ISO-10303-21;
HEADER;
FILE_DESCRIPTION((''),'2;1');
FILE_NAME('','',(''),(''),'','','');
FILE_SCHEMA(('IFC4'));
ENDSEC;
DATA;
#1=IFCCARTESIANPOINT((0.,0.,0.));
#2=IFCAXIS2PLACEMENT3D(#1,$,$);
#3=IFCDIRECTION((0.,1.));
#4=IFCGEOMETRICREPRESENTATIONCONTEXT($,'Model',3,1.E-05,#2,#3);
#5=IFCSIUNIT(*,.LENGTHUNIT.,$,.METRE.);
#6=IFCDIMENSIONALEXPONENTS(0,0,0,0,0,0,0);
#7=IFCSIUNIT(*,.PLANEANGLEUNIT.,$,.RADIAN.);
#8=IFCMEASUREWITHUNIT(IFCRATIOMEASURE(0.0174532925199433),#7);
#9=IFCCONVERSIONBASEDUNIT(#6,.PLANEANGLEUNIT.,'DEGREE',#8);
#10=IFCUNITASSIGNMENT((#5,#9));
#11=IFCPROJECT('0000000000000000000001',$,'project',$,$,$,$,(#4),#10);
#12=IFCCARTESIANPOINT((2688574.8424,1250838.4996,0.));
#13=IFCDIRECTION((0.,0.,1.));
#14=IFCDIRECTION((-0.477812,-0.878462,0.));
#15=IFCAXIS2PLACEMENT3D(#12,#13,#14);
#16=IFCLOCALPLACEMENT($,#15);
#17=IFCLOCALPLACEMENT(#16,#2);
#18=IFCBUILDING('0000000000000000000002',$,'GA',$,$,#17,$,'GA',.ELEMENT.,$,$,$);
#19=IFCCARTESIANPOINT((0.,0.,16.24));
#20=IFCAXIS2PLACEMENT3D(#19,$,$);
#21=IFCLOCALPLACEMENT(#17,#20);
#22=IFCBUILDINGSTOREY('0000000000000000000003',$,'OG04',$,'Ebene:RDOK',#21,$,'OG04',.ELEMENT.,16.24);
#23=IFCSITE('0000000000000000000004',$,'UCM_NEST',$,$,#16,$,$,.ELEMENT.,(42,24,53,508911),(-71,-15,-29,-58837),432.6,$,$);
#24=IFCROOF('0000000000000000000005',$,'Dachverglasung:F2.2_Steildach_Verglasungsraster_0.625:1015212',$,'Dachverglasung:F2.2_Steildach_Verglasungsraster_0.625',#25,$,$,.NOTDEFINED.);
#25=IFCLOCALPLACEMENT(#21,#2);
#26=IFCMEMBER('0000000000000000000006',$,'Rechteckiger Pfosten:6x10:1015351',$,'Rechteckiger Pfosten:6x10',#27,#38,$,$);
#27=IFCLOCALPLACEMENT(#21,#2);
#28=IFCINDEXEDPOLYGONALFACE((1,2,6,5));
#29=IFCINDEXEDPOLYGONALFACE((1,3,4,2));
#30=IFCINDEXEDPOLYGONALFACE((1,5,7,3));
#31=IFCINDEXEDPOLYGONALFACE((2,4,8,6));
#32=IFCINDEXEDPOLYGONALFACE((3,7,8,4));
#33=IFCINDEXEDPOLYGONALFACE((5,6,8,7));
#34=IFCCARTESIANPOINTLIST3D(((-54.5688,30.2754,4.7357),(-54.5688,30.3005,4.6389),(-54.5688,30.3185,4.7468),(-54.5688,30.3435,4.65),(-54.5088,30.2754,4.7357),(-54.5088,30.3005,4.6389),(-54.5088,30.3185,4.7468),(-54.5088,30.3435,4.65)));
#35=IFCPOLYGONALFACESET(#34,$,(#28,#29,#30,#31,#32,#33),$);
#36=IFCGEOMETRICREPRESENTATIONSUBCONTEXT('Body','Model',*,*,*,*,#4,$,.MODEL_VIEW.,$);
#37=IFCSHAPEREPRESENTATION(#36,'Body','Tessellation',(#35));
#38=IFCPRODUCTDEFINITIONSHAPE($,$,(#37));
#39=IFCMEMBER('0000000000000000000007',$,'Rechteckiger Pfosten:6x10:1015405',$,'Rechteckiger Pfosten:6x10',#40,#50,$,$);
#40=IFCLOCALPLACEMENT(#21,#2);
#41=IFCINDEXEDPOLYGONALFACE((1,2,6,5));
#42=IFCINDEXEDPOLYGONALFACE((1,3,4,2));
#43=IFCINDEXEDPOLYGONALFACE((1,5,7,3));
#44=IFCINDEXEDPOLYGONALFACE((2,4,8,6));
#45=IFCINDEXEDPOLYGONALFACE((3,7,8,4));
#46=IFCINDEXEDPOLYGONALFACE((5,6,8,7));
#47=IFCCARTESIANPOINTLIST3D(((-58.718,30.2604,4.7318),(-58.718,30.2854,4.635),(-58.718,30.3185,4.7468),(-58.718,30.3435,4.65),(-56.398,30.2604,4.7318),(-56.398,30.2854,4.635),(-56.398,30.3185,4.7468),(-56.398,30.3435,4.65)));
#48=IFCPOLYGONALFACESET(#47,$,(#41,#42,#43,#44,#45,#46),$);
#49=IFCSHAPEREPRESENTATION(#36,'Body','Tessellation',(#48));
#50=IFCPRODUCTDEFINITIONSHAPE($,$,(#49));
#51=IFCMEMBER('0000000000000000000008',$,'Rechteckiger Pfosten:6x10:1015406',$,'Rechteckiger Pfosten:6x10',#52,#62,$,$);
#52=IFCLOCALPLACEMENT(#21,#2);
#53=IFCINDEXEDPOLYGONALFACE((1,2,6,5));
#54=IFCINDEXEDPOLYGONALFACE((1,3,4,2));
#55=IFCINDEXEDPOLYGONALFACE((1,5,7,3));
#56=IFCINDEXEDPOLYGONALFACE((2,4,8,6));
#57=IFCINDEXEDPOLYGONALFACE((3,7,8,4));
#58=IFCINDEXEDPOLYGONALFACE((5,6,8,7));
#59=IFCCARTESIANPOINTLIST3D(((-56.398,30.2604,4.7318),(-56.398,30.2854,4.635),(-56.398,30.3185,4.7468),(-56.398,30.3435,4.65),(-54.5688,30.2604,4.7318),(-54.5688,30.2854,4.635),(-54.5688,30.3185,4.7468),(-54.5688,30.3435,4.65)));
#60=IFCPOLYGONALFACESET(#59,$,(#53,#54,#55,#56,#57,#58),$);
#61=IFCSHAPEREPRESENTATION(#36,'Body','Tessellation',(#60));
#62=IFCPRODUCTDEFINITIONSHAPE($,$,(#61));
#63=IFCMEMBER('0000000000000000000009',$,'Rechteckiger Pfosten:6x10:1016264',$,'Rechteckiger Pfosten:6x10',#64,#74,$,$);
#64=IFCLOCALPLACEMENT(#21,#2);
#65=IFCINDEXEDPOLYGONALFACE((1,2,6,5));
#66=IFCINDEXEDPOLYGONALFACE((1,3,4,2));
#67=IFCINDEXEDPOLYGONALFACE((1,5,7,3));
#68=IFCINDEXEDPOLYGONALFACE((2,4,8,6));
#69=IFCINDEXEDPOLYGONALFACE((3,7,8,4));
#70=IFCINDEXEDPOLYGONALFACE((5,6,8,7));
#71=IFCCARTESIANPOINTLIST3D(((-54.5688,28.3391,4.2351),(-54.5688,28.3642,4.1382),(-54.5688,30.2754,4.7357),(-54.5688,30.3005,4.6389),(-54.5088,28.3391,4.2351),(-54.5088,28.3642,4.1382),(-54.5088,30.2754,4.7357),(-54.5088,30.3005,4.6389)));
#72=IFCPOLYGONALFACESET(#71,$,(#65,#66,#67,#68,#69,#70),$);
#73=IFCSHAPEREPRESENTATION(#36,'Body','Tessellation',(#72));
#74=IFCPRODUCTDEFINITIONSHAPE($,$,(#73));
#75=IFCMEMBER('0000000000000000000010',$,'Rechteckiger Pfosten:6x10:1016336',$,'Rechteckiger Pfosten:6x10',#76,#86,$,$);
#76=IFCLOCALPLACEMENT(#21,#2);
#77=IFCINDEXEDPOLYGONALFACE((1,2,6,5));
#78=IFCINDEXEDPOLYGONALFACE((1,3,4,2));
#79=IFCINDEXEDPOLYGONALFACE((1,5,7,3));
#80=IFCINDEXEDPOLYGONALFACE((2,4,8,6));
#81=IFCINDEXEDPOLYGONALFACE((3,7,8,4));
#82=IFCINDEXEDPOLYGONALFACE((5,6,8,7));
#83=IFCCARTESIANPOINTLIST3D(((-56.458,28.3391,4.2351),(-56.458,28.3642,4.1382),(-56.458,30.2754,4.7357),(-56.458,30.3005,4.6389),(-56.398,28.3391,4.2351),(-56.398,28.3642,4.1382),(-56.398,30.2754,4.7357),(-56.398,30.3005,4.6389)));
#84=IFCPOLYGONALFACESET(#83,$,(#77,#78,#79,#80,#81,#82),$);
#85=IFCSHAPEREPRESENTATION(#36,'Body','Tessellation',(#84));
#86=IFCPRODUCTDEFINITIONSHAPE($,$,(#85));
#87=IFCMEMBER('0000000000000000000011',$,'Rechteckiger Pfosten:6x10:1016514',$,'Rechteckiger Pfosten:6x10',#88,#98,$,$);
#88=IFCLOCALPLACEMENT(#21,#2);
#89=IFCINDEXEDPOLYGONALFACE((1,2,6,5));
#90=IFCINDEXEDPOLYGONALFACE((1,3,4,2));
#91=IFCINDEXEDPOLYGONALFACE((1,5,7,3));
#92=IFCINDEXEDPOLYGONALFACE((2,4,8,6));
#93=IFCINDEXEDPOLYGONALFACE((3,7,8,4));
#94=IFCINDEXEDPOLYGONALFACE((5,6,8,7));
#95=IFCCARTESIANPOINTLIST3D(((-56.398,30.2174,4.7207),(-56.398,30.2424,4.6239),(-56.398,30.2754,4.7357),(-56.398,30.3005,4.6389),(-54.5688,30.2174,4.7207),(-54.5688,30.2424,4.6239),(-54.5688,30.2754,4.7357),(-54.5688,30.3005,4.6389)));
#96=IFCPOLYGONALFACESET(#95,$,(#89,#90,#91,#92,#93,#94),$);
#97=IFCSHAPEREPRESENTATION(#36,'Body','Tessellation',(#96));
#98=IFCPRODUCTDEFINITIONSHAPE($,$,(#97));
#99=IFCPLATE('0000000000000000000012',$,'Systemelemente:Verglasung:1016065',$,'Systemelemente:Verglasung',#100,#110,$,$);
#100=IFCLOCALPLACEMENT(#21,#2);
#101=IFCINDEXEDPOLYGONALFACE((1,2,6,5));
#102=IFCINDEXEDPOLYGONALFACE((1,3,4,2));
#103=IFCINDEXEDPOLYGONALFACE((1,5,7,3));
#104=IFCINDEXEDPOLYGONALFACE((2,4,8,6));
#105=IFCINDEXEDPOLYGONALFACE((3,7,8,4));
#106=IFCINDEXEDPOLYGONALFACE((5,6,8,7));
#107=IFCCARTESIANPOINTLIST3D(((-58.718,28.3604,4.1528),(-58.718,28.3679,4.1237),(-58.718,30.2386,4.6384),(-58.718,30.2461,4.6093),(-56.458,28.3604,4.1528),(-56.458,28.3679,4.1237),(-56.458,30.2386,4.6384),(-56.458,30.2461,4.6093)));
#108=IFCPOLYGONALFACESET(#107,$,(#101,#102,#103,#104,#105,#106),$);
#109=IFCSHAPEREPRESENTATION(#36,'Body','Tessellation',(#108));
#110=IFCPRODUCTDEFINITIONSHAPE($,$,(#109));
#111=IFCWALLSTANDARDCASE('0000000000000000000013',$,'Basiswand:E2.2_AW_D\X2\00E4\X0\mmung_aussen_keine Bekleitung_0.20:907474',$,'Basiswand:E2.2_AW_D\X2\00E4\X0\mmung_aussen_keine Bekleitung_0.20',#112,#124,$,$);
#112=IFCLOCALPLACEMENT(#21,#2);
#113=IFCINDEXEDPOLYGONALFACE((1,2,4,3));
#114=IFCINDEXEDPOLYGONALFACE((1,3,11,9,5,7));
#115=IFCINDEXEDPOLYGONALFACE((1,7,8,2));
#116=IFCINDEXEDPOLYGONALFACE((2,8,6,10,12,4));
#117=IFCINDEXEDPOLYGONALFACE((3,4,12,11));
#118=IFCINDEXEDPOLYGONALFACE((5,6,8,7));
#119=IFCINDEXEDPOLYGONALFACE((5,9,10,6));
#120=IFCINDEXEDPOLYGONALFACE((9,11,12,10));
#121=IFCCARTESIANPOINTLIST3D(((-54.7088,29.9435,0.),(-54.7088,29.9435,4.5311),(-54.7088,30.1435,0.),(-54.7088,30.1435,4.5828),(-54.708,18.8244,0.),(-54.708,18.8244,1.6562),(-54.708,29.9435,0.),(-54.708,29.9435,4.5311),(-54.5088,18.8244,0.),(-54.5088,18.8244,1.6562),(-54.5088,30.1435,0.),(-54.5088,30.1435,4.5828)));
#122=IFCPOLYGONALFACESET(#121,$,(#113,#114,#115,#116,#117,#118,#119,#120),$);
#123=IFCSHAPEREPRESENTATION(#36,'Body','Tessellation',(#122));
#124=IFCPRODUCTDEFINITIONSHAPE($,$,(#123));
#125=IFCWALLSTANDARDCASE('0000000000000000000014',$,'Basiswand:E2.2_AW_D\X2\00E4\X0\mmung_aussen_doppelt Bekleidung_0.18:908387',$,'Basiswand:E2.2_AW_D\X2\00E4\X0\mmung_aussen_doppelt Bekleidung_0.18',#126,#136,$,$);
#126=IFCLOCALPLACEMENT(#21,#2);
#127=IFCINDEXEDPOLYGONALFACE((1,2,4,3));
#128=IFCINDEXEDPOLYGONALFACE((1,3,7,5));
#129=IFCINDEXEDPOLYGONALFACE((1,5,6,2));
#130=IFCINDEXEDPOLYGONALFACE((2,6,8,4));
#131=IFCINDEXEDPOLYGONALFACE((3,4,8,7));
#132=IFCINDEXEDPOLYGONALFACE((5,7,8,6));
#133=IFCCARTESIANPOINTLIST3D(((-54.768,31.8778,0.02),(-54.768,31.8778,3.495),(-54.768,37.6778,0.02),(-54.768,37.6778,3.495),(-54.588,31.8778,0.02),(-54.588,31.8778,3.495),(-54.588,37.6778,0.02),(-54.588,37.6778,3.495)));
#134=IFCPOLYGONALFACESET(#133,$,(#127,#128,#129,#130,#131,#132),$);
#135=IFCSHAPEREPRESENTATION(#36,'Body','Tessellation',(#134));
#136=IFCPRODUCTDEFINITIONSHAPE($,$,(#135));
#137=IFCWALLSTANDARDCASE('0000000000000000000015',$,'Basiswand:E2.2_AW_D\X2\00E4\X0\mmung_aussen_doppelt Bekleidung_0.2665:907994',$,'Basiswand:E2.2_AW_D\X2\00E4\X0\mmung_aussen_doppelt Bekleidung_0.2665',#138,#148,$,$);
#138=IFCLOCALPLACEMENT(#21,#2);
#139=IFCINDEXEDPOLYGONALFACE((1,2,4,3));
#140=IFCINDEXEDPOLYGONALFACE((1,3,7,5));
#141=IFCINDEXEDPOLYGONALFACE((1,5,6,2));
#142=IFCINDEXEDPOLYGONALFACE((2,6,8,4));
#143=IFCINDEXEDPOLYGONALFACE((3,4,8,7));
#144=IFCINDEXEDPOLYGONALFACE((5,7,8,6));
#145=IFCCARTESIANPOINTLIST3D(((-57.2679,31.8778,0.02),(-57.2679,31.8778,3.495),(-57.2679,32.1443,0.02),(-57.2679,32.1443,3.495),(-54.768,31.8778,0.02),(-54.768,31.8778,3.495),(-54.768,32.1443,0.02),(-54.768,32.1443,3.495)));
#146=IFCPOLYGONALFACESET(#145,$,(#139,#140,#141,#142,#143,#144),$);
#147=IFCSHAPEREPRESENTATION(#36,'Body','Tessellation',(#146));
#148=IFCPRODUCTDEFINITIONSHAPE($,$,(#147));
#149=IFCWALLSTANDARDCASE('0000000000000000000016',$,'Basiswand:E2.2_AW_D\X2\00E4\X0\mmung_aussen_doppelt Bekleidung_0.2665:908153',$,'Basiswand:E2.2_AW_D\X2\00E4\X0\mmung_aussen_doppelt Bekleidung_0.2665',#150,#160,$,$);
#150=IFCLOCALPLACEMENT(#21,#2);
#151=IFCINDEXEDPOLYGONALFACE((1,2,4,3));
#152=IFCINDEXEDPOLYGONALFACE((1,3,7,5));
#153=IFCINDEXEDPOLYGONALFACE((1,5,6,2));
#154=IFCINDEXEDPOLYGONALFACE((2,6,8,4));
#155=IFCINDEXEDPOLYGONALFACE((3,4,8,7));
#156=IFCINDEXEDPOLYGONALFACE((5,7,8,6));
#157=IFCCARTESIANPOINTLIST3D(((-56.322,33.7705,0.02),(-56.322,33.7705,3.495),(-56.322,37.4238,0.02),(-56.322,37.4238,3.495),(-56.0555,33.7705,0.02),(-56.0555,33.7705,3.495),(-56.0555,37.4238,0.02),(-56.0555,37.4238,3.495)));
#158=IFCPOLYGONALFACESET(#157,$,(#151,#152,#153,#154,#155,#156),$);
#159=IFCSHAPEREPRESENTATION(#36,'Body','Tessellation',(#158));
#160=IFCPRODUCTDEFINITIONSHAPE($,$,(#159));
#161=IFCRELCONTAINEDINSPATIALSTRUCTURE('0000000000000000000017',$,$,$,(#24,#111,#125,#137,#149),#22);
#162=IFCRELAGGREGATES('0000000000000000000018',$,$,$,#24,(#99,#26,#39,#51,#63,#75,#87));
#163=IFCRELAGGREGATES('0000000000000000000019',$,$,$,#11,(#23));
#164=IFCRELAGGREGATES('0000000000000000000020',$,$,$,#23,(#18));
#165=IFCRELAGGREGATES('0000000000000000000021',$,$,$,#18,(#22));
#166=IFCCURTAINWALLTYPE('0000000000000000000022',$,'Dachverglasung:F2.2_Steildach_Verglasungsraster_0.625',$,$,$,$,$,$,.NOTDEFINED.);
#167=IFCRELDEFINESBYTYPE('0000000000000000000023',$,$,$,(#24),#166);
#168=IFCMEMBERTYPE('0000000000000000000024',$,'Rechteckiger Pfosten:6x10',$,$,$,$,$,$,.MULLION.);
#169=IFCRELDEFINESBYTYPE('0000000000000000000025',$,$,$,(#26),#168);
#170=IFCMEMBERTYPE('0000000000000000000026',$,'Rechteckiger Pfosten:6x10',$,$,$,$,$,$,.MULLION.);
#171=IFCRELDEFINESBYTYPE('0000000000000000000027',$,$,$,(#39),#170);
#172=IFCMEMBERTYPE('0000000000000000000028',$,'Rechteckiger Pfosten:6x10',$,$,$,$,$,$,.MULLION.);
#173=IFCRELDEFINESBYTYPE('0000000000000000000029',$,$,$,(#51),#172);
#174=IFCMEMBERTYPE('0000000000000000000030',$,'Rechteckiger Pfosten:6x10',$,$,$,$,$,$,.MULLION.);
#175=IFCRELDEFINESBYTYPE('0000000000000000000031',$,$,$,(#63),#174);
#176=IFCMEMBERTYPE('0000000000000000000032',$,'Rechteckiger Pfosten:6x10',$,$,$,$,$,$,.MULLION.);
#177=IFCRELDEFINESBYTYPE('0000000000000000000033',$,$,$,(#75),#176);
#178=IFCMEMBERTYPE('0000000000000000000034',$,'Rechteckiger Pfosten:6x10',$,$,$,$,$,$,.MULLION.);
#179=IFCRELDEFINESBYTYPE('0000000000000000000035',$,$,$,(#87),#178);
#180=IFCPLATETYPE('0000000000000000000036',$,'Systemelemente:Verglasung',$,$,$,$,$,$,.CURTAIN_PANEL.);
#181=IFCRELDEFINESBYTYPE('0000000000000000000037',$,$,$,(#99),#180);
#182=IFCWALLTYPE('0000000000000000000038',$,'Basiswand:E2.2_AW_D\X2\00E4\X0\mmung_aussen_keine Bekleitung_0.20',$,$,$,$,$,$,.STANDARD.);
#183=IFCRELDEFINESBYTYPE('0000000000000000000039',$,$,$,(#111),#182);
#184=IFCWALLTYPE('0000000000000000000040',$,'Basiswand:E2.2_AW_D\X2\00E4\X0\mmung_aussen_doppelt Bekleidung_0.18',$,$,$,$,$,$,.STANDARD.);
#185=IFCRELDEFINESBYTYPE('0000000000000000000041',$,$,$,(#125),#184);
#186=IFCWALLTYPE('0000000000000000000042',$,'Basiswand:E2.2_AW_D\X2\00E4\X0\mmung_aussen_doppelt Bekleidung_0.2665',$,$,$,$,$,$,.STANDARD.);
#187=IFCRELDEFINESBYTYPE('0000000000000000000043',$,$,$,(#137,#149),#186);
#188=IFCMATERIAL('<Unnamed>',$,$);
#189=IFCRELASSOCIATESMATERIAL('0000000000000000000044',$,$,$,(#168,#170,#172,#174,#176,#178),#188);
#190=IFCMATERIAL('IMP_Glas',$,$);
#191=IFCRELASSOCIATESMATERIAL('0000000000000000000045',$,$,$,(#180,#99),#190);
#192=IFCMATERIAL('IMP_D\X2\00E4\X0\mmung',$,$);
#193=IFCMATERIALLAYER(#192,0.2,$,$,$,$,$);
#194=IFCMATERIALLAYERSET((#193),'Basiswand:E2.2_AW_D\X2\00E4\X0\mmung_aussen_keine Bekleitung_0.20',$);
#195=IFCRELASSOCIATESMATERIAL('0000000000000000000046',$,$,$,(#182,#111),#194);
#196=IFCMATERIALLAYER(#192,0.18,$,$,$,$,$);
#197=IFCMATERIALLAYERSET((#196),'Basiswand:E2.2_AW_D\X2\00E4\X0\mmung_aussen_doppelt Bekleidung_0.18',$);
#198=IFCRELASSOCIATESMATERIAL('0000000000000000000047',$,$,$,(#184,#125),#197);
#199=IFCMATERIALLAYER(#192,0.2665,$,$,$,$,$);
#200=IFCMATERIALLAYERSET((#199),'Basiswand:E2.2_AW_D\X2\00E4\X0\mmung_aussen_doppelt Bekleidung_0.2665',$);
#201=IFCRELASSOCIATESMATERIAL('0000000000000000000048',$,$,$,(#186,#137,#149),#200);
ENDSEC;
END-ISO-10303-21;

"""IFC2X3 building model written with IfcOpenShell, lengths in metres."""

from ifc_helpers import new_model, entity, si_unit, converted_unit, direction, frame, frame_2d, origin, origin_2d_with_axis, place, context, subcontext, project, spatial, polyline, rectangle, extrude, clip, halfspace, bounded_halfspace, source, transform, mapped, material, layer, layer_set, layer_usage, type_object, type_shapes, element, aggregate, save


model = new_model("IFC2X3")

# Units and contexts
model_context = context("Model", 3, precision=1e-05, world=origin(), true_north=direction((0.0, 1.0)))
body_context = subcontext(model_context, "Body", "Model", "MODEL_VIEW")
ifc_project = project(units=[si_unit("LENGTHUNIT", "METRE"), converted_unit("PLANEANGLEUNIT", "DEGREE", entity("IfcRatioMeasure", 0.0174532925199433), si_unit("PLANEANGLEUNIT", "RADIAN"), dimensions=[0, 0, 0, 0, 0, 0, 0])], contexts=[model_context])

# Site, building, storey
site_placement = place(None, frame((2688574.8424, 1250838.4996, 0.0), z_axis=(0.0, 0.0, 1.0), x_axis=(-0.477812, -0.878462, 0.0)))
site = spatial("IfcSite", under=ifc_project, at=site_placement, Name="UCM_NEST", CompositionType="ELEMENT", RefLatitude=(42, 24, 53, 508911), RefLongitude=(-71, -15, -29, -58837), RefElevation=432.6)
building_placement = place(site_placement, origin())
building = spatial("IfcBuilding", under=site, at=building_placement, Name="GA", LongName="GA", CompositionType="ELEMENT")
storey_placement = place(building_placement, frame((0.0, 0.0, 16.24)))
storey = spatial("IfcBuildingStorey", under=building, at=storey_placement, Name="OG04", ObjectType="Ebene:RDOK", LongName="OG04", CompositionType="ELEMENT", Elevation=16.24)

# Roof, members, plate
curtain_wall_type = type_object("IfcCurtainWallType", Name="Dachverglasung:F2.2_Steildach_Verglasungsraster_0.625", PredefinedType="NOTDEFINED")
roof_placement = place(storey_placement, frame((0.0, 0.0, -16.24)))
roof = element("IfcRoof", 1, at=roof_placement, inside=storey, type_object=curtain_wall_type, Name="Dachverglasung:F2.2_Steildach_Verglasungsraster_0.625:1015212", ObjectType="Dachverglasung:F2.2_Steildach_Verglasungsraster_0.625", ShapeType="NOTDEFINED")
ifc_material_1 = material(Name="<Unnamed>")
member_type_1 = type_object("IfcMemberType", Name="Rechteckiger Pfosten:6x10", PredefinedType="MULLION", material=ifc_material_1)
shared_shape_1 = source(origin(), body_context, "Body", "SweptSolid", [
    extrude(rectangle(XDim=0.1, YDim=0.06, at=origin_2d_with_axis()), frame((-0.03, -0.05, -0.0444), z_axis=(0.0, 0.0, 1.0), x_axis=(0.0, -1.0, 0.0)), (0.0, 0.0, 1.0), 0.0444),
])
type_shapes(member_type_1, [shared_shape_1])
member_1_placement = place(roof_placement, frame((-54.5088, 30.3435, 20.89), z_axis=(0.0, 0.968163, 0.250322), x_axis=(1.0, 0.0, 0.0)))
member_1 = element("IfcMember", 2, at=member_1_placement, type_object=member_type_1, Name="Rechteckiger Pfosten:6x10:1015351", ObjectType="Rechteckiger Pfosten:6x10", context=body_context, shape_type="MappedRepresentation", body=[
    mapped(shared_shape_1, transform((0.0, 0.0, 0.0), scale=1.0)),
])
member_type_2 = type_object("IfcMemberType", Name="Rechteckiger Pfosten:6x10", PredefinedType="MULLION", material=ifc_material_1)
shared_shape_2 = source(origin(), body_context, "Body", "SweptSolid", [
    extrude(rectangle(XDim=0.1, YDim=0.06, at=origin_2d_with_axis()), frame((-0.03, -0.05, -2.32), z_axis=(0.0, 0.0, 1.0), x_axis=(0.0, -1.0, 0.0)), (0.0, 0.0, 1.0), 2.32),
])
type_shapes(member_type_2, [shared_shape_2])
member_2_placement = place(roof_placement, frame((-58.718, 30.3435, 20.89), z_axis=(-1.0, 0.0, 0.0), x_axis=(0.0, 0.968163, 0.250322)))
member_2 = element("IfcMember", 3, at=member_2_placement, type_object=member_type_2, Name="Rechteckiger Pfosten:6x10:1015405", ObjectType="Rechteckiger Pfosten:6x10", context=body_context, shape_type="MappedRepresentation", body=[
    mapped(shared_shape_2, transform((0.0, 0.0, 0.0), scale=1.0)),
])
member_type_3 = type_object("IfcMemberType", Name="Rechteckiger Pfosten:6x10", PredefinedType="MULLION", material=ifc_material_1)
shared_shape_3 = source(origin(), body_context, "Body", "SweptSolid", [
    extrude(rectangle(XDim=0.1, YDim=0.06, at=origin_2d_with_axis()), frame((-0.03, -0.05, -1.8292), z_axis=(0.0, 0.0, 1.0), x_axis=(0.0, -1.0, 0.0)), (0.0, 0.0, 1.0), 1.8292),
])
type_shapes(member_type_3, [shared_shape_3])
member_3_placement = place(roof_placement, frame((-56.398, 30.3435, 20.89), z_axis=(-1.0, 0.0, 0.0), x_axis=(0.0, 0.968163, 0.250322)))
member_3 = element("IfcMember", 4, at=member_3_placement, type_object=member_type_3, Name="Rechteckiger Pfosten:6x10:1015406", ObjectType="Rechteckiger Pfosten:6x10", context=body_context, shape_type="MappedRepresentation", body=[
    mapped(shared_shape_3, transform((0.0, 0.0, 0.0), scale=1.0)),
])
member_type_4 = type_object("IfcMemberType", Name="Rechteckiger Pfosten:6x10", PredefinedType="MULLION", material=ifc_material_1)
shared_shape_4 = source(origin(), body_context, "Body", "SweptSolid", [
    extrude(rectangle(XDim=0.1, YDim=0.06, at=origin_2d_with_axis()), frame((-0.03, -0.05, -2.0), z_axis=(0.0, 0.0, 1.0), x_axis=(0.0, -1.0, 0.0)), (0.0, 0.0, 1.0), 2.0),
])
type_shapes(member_type_4, [shared_shape_4])
member_4_placement = place(roof_placement, frame((-54.5088, 30.3005, 20.8789), z_axis=(0.0, 0.968163, 0.250322), x_axis=(1.0, 0.0, 0.0)))
member_4 = element("IfcMember", 5, at=member_4_placement, type_object=member_type_4, Name="Rechteckiger Pfosten:6x10:1016264", ObjectType="Rechteckiger Pfosten:6x10", context=body_context, shape_type="MappedRepresentation", body=[
    mapped(shared_shape_4, transform((0.0, 0.0, 0.0), scale=1.0)),
])
member_type_5 = type_object("IfcMemberType", Name="Rechteckiger Pfosten:6x10", PredefinedType="MULLION", material=ifc_material_1)
shared_shape_5 = source(origin(), body_context, "Body", "SweptSolid", [
    extrude(rectangle(XDim=0.1, YDim=0.06, at=origin_2d_with_axis()), frame((-0.03, -0.05, -2.0), z_axis=(0.0, 0.0, 1.0), x_axis=(0.0, -1.0, 0.0)), (0.0, 0.0, 1.0), 2.0),
])
type_shapes(member_type_5, [shared_shape_5])
member_5_placement = place(roof_placement, frame((-56.398, 30.3005, 20.8789), z_axis=(0.0, 0.968163, 0.250322), x_axis=(1.0, 0.0, 0.0)))
member_5 = element("IfcMember", 6, at=member_5_placement, type_object=member_type_5, Name="Rechteckiger Pfosten:6x10:1016336", ObjectType="Rechteckiger Pfosten:6x10", context=body_context, shape_type="MappedRepresentation", body=[
    mapped(shared_shape_5, transform((0.0, 0.0, 0.0), scale=1.0)),
])
member_type_6 = type_object("IfcMemberType", Name="Rechteckiger Pfosten:6x10", PredefinedType="MULLION", material=ifc_material_1)
shared_shape_6 = source(origin(), body_context, "Body", "SweptSolid", [
    extrude(rectangle(XDim=0.1, YDim=0.06, at=origin_2d_with_axis()), frame((-0.03, -0.05, -1.8292), z_axis=(0.0, 0.0, 1.0), x_axis=(0.0, -1.0, 0.0)), (0.0, 0.0, 1.0), 1.8292),
])
type_shapes(member_type_6, [shared_shape_6])
member_6_placement = place(roof_placement, frame((-56.398, 30.3005, 20.8789), z_axis=(-1.0, 0.0, 0.0), x_axis=(0.0, 0.968163, 0.250322)))
member_6 = element("IfcMember", 7, at=member_6_placement, type_object=member_type_6, Name="Rechteckiger Pfosten:6x10:1016514", ObjectType="Rechteckiger Pfosten:6x10", context=body_context, shape_type="MappedRepresentation", body=[
    mapped(shared_shape_6, transform((0.0, 0.0, 0.0), scale=1.0)),
])
ifc_material_2 = material(Name="IMP_Glas")
plate_type = type_object("IfcPlateType", Name="Systemelemente:Verglasung", PredefinedType="CURTAIN_PANEL", material=ifc_material_2)
shared_shape_7 = source(origin(), body_context, "Body", "SweptSolid", [
    extrude(rectangle(XDim=0.03, YDim=2.26, at=origin_2d_with_axis()), frame((0.0, 0.0, 0.0), z_axis=(0.0, 0.0, 1.0), x_axis=(0.0, 1.0, 0.0)), (0.0, 0.0, 1.0), 1.94),
])
type_shapes(plate_type, [shared_shape_7])
plate_placement = place(roof_placement, frame((-57.588, 28.3642, 20.3782), z_axis=(0.0, 0.968163, 0.250322), x_axis=(1.0, 0.0, 0.0)))
plate = element("IfcPlate", 8, at=plate_placement, type_object=plate_type, material=ifc_material_2, Name="Systemelemente:Verglasung:1016065", ObjectType="Systemelemente:Verglasung", context=body_context, shape_type="MappedRepresentation", body=[
    mapped(shared_shape_7, transform((0.0, 0.0, 0.0), scale=1.0)),
])
aggregate(roof, [plate, member_1, member_2, member_3, member_4, member_5, member_6])

# Walls
ifc_material_3 = material(Name="IMP_Dämmung")
ifc_layer_1 = layer(ifc_material_3, 0.2)
ifc_layer_set_1 = layer_set([ifc_layer_1], Name="Basiswand:E2.2_AW_Dämmung_aussen_keine Bekleitung_0.20")
ifc_layer_usage_1 = layer_usage(ifc_layer_set_1, "AXIS2", "NEGATIVE", 0.1)
wall_type_1 = type_object("IfcWallType", Name="Basiswand:E2.2_AW_Dämmung_aussen_keine Bekleitung_0.20", PredefinedType="STANDARD", material=ifc_layer_set_1)
wall_1_placement = place(storey_placement, frame((-54.6088, 30.1435, 0.0), z_axis=(0.0, 0.0, 1.0), x_axis=(0.0, -1.0, 0.0)))
element("IfcWallStandardCase", 9, at=wall_1_placement, inside=storey, type_object=wall_type_1, material=ifc_layer_usage_1, Name="Basiswand:E2.2_AW_Dämmung_aussen_keine Bekleitung_0.20:907474", ObjectType="Basiswand:E2.2_AW_Dämmung_aussen_keine Bekleitung_0.20", context=body_context, shape_type="Clipping", body=[
    clip(clip(clip(extrude(rectangle(XDim=11.319, YDim=0.2, at=frame_2d((5.6595, 0.0), x_axis=(-1.0, 0.0))), origin(), (0.0, 0.0, 1.0), 4.5828), bounded_halfspace(frame((0.2, -0.0992, 4.5311), z_axis=(0.0, 1.0, 0.0), x_axis=(-1.0, 0.0, 0.0)), True, frame((0.2, -0.0992, 4.5311), z_axis=(0.0, 1.0, 0.0), x_axis=(-1.0, 0.0, 0.0)), polyline([(0.0, 0.0), (-11.119, -2.8749), (-11.119, -4.5311), (0.0, -4.5311), (0.0, 0.0)]))), bounded_halfspace(frame((0.2, -0.0992, 0.0), z_axis=(1.0, 0.0, 0.0), x_axis=(0.0, 1.0, 0.0)), False, frame((0.2, -0.0992, 0.0), z_axis=(1.0, 0.0, 0.0), x_axis=(0.0, 1.0, 0.0)), polyline([(0.0, 0.0), (0.0, 4.5311), (-0.0008, 4.5311), (-0.0008, 0.0), (0.0, 0.0)]))), halfspace(frame((11.319, 0.1, 1.6562), z_axis=(0.250322, 0.0, 0.968163), x_axis=(0.0, 1.0, 0.0)), False)),
])
ifc_layer_2 = layer(ifc_material_3, 0.18)
ifc_layer_set_2 = layer_set([ifc_layer_2], Name="Basiswand:E2.2_AW_Dämmung_aussen_doppelt Bekleidung_0.18")
ifc_layer_usage_2 = layer_usage(ifc_layer_set_2, "AXIS2", "NEGATIVE", 0.09)
wall_type_2 = type_object("IfcWallType", Name="Basiswand:E2.2_AW_Dämmung_aussen_doppelt Bekleidung_0.18", PredefinedType="STANDARD", material=ifc_layer_set_2)
wall_2_placement = place(storey_placement, frame((-54.678, 31.8778, 0.02), z_axis=(0.0, 0.0, 1.0), x_axis=(0.0, 1.0, 0.0)))
element("IfcWallStandardCase", 10, at=wall_2_placement, inside=storey, type_object=wall_type_2, material=ifc_layer_usage_2, Name="Basiswand:E2.2_AW_Dämmung_aussen_doppelt Bekleidung_0.18:908387", ObjectType="Basiswand:E2.2_AW_Dämmung_aussen_doppelt Bekleidung_0.18", context=body_context, shape_type="SweptSolid", body=[
    extrude(rectangle(XDim=5.8, YDim=0.18, at=frame_2d((2.9, 0.0), x_axis=(-1.0, 0.0))), origin(), (0.0, 0.0, 1.0), 3.475),
])
ifc_layer_3 = layer(ifc_material_3, 0.2665)
ifc_layer_set_3 = layer_set([ifc_layer_3], Name="Basiswand:E2.2_AW_Dämmung_aussen_doppelt Bekleidung_0.2665")
ifc_layer_usage_3 = layer_usage(ifc_layer_set_3, "AXIS2", "NEGATIVE", 0.1333)
wall_type_3 = type_object("IfcWallType", Name="Basiswand:E2.2_AW_Dämmung_aussen_doppelt Bekleidung_0.2665", PredefinedType="STANDARD", material=ifc_layer_set_3)
wall_3_placement = place(storey_placement, frame((-57.2679, 32.011, 0.02)))
element("IfcWallStandardCase", 11, at=wall_3_placement, inside=storey, type_object=wall_type_3, material=ifc_layer_usage_3, Name="Basiswand:E2.2_AW_Dämmung_aussen_doppelt Bekleidung_0.2665:907994", ObjectType="Basiswand:E2.2_AW_Dämmung_aussen_doppelt Bekleidung_0.2665", context=body_context, shape_type="SweptSolid", body=[
    extrude(rectangle(XDim=2.4999, YDim=0.2665, at=frame_2d((1.25, 0.0), x_axis=(-1.0, 0.0))), origin(), (0.0, 0.0, 1.0), 3.475),
])

# Wall
ifc_layer_usage_4 = layer_usage(ifc_layer_set_3, "AXIS2", "NEGATIVE", 0.1333)
wall_4_placement = place(storey_placement, frame((-56.1887, 33.7705, 0.02), z_axis=(0.0, 0.0, 1.0), x_axis=(0.0, 1.0, 0.0)))
element("IfcWallStandardCase", 12, at=wall_4_placement, inside=storey, type_object=wall_type_3, material=ifc_layer_usage_4, Name="Basiswand:E2.2_AW_Dämmung_aussen_doppelt Bekleidung_0.2665:908153", ObjectType="Basiswand:E2.2_AW_Dämmung_aussen_doppelt Bekleidung_0.2665", context=body_context, shape_type="SweptSolid", body=[
    extrude(rectangle(XDim=3.6533, YDim=0.2665, at=frame_2d((1.8266, 0.0), x_axis=(-1.0, 0.0))), origin(), (0.0, 0.0, 1.0), 3.475),
])

save(model, "model.ifc")
